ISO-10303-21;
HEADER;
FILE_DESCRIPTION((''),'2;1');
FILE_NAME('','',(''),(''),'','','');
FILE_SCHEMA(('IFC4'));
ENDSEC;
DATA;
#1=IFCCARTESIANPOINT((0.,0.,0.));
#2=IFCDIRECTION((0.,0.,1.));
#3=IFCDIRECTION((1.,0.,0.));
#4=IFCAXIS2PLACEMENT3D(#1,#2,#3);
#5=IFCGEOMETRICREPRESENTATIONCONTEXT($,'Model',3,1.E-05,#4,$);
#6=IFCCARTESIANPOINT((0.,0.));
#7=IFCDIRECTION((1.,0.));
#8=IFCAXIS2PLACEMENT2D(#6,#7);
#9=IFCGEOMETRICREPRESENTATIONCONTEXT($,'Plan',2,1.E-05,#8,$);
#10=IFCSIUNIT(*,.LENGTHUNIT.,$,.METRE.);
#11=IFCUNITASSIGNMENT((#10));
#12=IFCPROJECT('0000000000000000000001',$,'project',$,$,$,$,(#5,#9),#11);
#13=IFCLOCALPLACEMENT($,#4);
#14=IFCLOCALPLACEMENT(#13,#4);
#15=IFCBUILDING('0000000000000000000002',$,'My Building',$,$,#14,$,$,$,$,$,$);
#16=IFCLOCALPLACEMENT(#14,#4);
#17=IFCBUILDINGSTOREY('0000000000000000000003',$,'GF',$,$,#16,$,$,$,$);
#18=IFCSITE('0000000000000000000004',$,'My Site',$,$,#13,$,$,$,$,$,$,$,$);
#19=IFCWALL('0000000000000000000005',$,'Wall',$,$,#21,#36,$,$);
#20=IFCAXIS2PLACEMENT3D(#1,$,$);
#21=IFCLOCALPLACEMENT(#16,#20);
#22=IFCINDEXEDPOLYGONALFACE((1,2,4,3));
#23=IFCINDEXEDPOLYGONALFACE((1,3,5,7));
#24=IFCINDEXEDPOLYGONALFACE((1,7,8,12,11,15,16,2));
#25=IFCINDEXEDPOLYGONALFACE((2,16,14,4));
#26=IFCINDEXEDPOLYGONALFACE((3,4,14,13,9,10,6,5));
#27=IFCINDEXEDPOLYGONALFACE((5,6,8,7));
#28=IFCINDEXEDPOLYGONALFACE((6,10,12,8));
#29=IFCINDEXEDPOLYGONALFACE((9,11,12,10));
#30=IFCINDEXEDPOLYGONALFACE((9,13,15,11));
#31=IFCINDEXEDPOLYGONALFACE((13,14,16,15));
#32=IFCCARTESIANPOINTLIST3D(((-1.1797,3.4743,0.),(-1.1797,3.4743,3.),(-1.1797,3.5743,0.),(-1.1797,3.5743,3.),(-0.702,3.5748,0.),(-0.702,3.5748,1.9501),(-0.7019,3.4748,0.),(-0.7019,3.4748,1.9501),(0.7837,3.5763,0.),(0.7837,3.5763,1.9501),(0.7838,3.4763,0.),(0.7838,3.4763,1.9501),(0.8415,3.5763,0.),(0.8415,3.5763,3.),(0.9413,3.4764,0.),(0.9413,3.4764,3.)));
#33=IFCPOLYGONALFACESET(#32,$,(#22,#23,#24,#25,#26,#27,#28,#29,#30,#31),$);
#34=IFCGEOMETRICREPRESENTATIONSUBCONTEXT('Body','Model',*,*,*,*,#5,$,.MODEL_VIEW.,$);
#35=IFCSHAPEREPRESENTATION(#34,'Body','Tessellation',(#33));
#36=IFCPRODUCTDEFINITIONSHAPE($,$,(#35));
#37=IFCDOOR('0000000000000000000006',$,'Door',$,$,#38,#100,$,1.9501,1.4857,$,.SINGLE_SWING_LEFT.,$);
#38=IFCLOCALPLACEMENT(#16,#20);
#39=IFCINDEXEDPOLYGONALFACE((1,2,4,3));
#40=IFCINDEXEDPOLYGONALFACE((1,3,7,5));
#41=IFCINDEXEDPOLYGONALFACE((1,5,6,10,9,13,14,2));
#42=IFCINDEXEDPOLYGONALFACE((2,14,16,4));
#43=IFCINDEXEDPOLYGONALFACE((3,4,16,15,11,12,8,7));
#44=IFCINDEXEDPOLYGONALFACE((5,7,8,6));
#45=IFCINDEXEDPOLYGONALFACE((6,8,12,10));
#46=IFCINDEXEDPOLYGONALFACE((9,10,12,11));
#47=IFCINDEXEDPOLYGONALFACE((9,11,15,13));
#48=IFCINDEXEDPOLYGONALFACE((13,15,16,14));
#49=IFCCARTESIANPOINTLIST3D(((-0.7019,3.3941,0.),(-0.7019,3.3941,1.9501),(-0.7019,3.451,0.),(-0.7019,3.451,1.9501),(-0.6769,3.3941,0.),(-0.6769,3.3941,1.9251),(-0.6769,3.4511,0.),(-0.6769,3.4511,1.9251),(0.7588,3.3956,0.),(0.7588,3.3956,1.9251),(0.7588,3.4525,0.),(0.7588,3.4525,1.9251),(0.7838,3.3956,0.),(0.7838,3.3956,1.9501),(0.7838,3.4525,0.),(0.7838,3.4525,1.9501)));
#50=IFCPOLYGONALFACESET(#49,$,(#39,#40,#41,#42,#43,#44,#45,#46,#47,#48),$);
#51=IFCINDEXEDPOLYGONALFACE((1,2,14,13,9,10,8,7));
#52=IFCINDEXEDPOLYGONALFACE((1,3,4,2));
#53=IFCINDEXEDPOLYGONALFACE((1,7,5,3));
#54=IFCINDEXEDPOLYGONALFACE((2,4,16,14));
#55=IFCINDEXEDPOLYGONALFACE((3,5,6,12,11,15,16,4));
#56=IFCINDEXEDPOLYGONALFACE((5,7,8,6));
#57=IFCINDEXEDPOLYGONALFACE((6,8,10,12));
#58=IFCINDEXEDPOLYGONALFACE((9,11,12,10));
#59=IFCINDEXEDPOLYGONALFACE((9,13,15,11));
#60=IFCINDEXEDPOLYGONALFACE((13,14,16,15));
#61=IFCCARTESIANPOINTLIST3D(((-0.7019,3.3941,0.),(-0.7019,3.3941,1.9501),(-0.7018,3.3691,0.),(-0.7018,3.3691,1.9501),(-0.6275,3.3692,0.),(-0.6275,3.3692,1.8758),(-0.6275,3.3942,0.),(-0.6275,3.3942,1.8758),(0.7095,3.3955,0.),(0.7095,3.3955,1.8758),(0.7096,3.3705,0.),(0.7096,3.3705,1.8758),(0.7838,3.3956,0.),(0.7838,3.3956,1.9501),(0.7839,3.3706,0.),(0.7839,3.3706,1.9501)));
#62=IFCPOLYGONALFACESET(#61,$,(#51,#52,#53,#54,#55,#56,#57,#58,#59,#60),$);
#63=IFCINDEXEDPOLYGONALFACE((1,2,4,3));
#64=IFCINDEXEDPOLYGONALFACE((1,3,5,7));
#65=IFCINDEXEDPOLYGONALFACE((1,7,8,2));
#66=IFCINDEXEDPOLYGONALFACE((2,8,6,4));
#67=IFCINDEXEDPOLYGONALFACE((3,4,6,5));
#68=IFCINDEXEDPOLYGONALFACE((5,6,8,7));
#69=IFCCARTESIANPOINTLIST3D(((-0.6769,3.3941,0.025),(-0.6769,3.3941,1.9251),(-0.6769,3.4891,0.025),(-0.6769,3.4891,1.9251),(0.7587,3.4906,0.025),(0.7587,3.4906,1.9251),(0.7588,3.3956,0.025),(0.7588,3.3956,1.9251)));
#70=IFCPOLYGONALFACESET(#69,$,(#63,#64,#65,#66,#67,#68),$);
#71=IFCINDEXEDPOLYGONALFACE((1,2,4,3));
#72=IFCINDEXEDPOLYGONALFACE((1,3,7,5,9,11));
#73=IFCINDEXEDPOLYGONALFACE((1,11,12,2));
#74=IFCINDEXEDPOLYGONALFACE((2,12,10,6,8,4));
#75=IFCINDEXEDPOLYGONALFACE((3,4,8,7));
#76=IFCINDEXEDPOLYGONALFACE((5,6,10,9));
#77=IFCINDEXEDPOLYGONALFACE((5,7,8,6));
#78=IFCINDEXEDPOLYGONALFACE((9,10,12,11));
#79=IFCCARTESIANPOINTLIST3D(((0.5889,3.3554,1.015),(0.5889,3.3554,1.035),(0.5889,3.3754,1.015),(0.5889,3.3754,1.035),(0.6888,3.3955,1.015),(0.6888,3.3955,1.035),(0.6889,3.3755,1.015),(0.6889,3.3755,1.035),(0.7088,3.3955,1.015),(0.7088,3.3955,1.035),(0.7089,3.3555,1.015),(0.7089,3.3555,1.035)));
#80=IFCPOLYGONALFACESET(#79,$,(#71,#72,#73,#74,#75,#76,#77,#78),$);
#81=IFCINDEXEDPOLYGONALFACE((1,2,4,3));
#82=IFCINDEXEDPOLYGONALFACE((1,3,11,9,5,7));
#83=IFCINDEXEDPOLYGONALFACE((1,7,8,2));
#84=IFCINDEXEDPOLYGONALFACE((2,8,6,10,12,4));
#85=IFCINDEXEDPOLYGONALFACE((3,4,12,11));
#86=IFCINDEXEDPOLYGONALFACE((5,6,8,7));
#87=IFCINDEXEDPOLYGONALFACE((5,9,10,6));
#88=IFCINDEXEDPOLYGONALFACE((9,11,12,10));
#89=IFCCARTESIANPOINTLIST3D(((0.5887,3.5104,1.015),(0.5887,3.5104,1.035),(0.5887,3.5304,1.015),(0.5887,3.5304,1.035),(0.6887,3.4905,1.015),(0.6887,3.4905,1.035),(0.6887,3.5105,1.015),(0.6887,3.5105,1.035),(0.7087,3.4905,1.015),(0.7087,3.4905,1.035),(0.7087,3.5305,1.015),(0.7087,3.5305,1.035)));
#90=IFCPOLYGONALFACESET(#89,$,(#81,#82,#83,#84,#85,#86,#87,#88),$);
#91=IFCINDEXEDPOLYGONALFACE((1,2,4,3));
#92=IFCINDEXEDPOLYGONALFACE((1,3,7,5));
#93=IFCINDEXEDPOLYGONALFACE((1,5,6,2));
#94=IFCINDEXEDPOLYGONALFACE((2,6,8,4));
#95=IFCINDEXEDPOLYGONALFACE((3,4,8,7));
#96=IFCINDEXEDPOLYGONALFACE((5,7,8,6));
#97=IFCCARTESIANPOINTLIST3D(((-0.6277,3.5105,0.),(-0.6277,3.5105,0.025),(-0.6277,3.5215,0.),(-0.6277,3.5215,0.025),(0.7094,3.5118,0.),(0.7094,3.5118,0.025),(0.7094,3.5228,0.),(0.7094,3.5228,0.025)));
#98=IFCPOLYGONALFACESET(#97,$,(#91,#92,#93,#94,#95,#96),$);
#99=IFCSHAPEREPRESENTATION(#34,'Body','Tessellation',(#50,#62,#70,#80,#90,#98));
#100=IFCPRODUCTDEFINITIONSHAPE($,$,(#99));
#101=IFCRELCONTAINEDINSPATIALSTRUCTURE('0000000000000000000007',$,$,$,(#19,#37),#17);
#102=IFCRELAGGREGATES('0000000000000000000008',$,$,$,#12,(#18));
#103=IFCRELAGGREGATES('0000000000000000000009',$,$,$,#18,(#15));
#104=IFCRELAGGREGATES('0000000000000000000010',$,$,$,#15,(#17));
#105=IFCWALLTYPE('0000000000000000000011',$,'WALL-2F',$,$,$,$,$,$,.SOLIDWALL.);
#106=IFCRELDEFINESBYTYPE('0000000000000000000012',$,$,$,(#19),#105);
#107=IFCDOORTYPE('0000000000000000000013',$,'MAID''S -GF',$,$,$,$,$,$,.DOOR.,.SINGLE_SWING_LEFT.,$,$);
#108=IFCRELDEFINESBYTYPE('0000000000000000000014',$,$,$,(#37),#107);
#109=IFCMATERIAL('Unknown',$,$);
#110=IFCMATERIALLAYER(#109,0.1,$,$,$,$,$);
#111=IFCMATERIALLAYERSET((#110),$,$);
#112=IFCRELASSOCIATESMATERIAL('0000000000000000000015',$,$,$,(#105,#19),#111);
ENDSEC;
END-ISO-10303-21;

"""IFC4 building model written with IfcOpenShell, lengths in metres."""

from ifc_helpers import new_model, entity, si_unit, frame, origin_with_axes, origin_2d_with_axis, place, context, subcontext, project, spatial, line, indexed_curve, outline, extrude, shape, source, transform, mapped, material, layer, layer_set, layer_usage, type_object, type_shapes, element, fill, save


model = new_model("IFC4")

# Units and contexts
model_context = context("Model", 3, precision=1e-05, world=origin_with_axes())
plan_context = context("Plan", 2, precision=1e-05, world=origin_2d_with_axis())
body_context_1 = subcontext(model_context, "Body", "Model", "MODEL_VIEW")
body_context_2 = subcontext(plan_context, "Body", "Plan", "PLAN_VIEW")
ifc_project = project(units=[si_unit("LENGTHUNIT", "METRE")], contexts=[model_context, plan_context])

# Site, building, storey
site_placement = place(None, origin_with_axes())
site = spatial("IfcSite", under=ifc_project, at=site_placement, Name="My Site")
building_placement = place(site_placement, origin_with_axes())
building = spatial("IfcBuilding", under=site, at=building_placement, Name="My Building")
storey_placement = place(building_placement, origin_with_axes())
storey = spatial("IfcBuildingStorey", under=building, at=storey_placement, Name="GF")

# Shared definitions
ifc_material = material(Name="Unknown")

# Shared definitions
ifc_layer_1 = layer(ifc_material, 0.1)
ifc_layer_set_1 = layer_set([ifc_layer_1])
wall_type = type_object("IfcWallType", Name="WALL-2F", PredefinedType="SOLIDWALL", material=ifc_layer_set_1)

# Wall, opening, door
ifc_layer_usage_1 = layer_usage(ifc_layer_set_1, "AXIS2", "POSITIVE", 0.0)
wall_1_placement = place(storey_placement, frame((0.8415, 3.5763, 0.0), z_axis=(0.0, 0.0, 1.0), x_axis=(-1.0, -0.000997, 0.0)))
wall_1 = element("IfcWall", 1, at=wall_1_placement, inside=storey, type_object=wall_type, material=ifc_layer_usage_1, Name="Wall", context=body_context_1, shape_type="SweptSolid", body=[
    extrude(outline(indexed_curve([(0.0, 0.0), (-0.0997, 0.1), (2.0213, 0.1), (2.0212, 0.0)], segments=[line(1, 2, 3, 4, 1)])), origin_with_axes(), (0.0, 0.0, 1.0), 3.0),
])
shared_shape_1 = source(origin_with_axes(), body_context_1, "Body", "SweptSolid", [
    extrude(outline(indexed_curve([(0.0, 0.0), (1.4857, 0.0), (1.4857, 1.9501), (0.0, 1.9501)], segments=[line(1, 2, 3, 4, 1)])), frame((0.0, -0.6, 0.0), z_axis=(0.0, -1.0, 0.0), x_axis=(1.0, 0.0, 0.0)), (0.0, 0.0, -1.0), 1.2),
])
opening_1_placement = place(wall_1_placement, frame((1.5436, 0.19, 0.0), z_axis=(0.0, 0.0, 1.0), x_axis=(-1.0, 0.000001, 0.0)))
opening_1 = element("IfcOpeningElement", 2, at=opening_1_placement, cuts=wall_1, PredefinedType="OPENING", context=body_context_1, shape_type="MappedRepresentation", body=[
    mapped(shared_shape_1, transform((0.0, 0.0, 0.0), x_axis=(1.0, 0.0, 0.0), y_axis=(0.0, 1.0, 0.0), z_axis=(0.0, 0.0, 1.0), scale=1.0)),
])
door_type_1 = type_object("IfcDoorType", Name="MAID'S -GF", OperationType="SINGLE_SWING_LEFT", PredefinedType="DOOR")
shared_shape_2 = source(origin_with_axes(), body_context_1, "Body", "SweptSolid", [
    extrude(outline(indexed_curve([(0.0, 0.0), (0.0, 1.9501), (1.4857, 1.9501), (1.4857, 0.0), (1.4607, 0.0), (1.4607, 1.9251), (0.025, 1.9251), (0.025, 0.0)], segments=[line(1, 2, 3, 4, 5, 6, 7, 8, 1)])), frame((0.0, 0.0093, 0.0), z_axis=(0.0, -1.0, 0.0), x_axis=(1.0, 0.0, 0.0)), (0.0, 0.0, -1.0), 0.0569),
    extrude(outline(indexed_curve([(0.0, 0.0), (0.0, 1.9501), (1.4857, 1.9501), (1.4857, 0.0), (1.4114, 0.0), (1.4114, 1.8758), (0.0743, 1.8758), (0.0743, 0.0)], segments=[line(1, 2, 3, 4, 5, 6, 7, 8, 1)])), frame((0.0, -0.0157, 0.0), z_axis=(0.0, -1.0, 0.0), x_axis=(1.0, 0.0, 0.0)), (0.0, 0.0, -1.0), 0.025),
    extrude(outline(indexed_curve([(0.0, 0.0), (1.4357, 0.0), (1.4357, 0.095), (0.0, 0.095)], segments=[line(1, 2, 3, 4, 1)])), frame((0.025, 0.0093, 0.025), z_axis=(0.0, 0.0, 1.0), x_axis=(1.0, 0.0, 0.0)), (0.0, 0.0, 1.0), 1.9001),
    extrude(outline(indexed_curve([(0.0, 0.0), (0.0, -0.04), (-0.12, -0.04), (-0.12, -0.02), (-0.02, -0.02), (-0.02, 0.0)], segments=[line(1, 2, 3, 4, 5, 6, 1)])), frame((1.4107, 0.0093, 1.015), z_axis=(0.0, 0.0, 1.0), x_axis=(1.0, 0.0, 0.0)), (0.0, 0.0, 1.0), 0.02),
    extrude(outline(indexed_curve([(0.0, 0.0), (0.0, 0.04), (-0.12, 0.04), (-0.12, 0.02), (-0.02, 0.02), (-0.02, 0.0)], segments=[line(1, 2, 3, 4, 5, 6, 1)])), frame((1.4107, 0.1043, 1.015), z_axis=(0.0, 0.0, 1.0), x_axis=(1.0, 0.0, 0.0)), (0.0, 0.0, 1.0), 0.02),
    extrude(outline(indexed_curve([(0.0, 0.0), (1.3371, 0.0), (1.3371, 0.011), (0.0, 0.011)], segments=[line(1, 2, 3, 4, 1)])), frame((0.0743, 0.1256, 0.0), z_axis=(0.0, 0.0, 1.0), x_axis=(1.0, 0.0, 0.0)), (0.0, 0.0, 1.0), 0.025),
])
shared_shape_3 = source(origin_with_axes(), body_context_2, "Body", "Curve2D", [
    entity("IfcIndexedPolyCurve", entity("IfcCartesianPointList2D", [[0.0, -0.0157], [0.0, 0.0662], [0.025, 0.0662], [0.025, 0.0093], [0.0743, 0.0093], [0.0743, -0.0157]]), [entity("IfcLineIndex", [1, 2, 3, 4, 5, 6, 1])]),
    entity("IfcIndexedPolyCurve", entity("IfcCartesianPointList2D", [[1.4857, -0.0157], [1.4857, 0.0662], [1.4607, 0.0662], [1.4607, 0.0093], [1.4114, 0.0093], [1.4114, -0.0157]]), [entity("IfcLineIndex", [1, 2, 3, 4, 5, 6, 1])]),
    entity("IfcTrimmedCurve", entity("IfcEllipse", entity("IfcAxis2Placement2D", entity("IfcCartesianPoint", [0.12, 0.0662]), entity("IfcDirection", [1.0, 0.0])), 1.3407, 1.4357), [entity("IfcCartesianPoint", [1.4607, 0.0662])], [entity("IfcCartesianPoint", [0.12, 1.5019])], True, "CARTESIAN"),
    entity("IfcIndexedPolyCurve", entity("IfcCartesianPointList2D", [[0.025, 0.0662], [0.12, 0.0662], [0.12, 1.5019], [0.025, 1.5019]]), [entity("IfcLineIndex", [1, 2, 3, 4, 1])]),
])
type_shapes(door_type_1, [shared_shape_2, shared_shape_3])
door_1_placement = place(opening_1_placement, frame((0.0, 0.0, 0.0), z_axis=(0.0, 0.0, 1.0), x_axis=(1.0, 0.0, 0.0)))
door_1 = element("IfcDoor", 3, at=door_1_placement, inside=storey, type_object=door_type_1, Name="Door", OperationType="SINGLE_SWING_LEFT", OverallHeight=1.9501, OverallWidth=1.4857, shapes=[
    shape(body_context_1, "Body", "MappedRepresentation", [mapped(shared_shape_2, transform((0.0, 0.0, 0.0), x_axis=(1.0, 0.0, 0.0), y_axis=(0.0, 1.0, 0.0), z_axis=(0.0, 0.0, 1.0), scale=1.0))]),
    shape(body_context_2, "Body", "MappedRepresentation", [mapped(shared_shape_3, transform((0.0, 0.0, 0.0), x_axis=(1.0, 0.0, 0.0), y_axis=(0.0, 1.0, 0.0), z_axis=(0.0, 0.0, 1.0), scale=1.0))]),
])
fill(opening_1, door_1)

save(model, "model.ifc")
